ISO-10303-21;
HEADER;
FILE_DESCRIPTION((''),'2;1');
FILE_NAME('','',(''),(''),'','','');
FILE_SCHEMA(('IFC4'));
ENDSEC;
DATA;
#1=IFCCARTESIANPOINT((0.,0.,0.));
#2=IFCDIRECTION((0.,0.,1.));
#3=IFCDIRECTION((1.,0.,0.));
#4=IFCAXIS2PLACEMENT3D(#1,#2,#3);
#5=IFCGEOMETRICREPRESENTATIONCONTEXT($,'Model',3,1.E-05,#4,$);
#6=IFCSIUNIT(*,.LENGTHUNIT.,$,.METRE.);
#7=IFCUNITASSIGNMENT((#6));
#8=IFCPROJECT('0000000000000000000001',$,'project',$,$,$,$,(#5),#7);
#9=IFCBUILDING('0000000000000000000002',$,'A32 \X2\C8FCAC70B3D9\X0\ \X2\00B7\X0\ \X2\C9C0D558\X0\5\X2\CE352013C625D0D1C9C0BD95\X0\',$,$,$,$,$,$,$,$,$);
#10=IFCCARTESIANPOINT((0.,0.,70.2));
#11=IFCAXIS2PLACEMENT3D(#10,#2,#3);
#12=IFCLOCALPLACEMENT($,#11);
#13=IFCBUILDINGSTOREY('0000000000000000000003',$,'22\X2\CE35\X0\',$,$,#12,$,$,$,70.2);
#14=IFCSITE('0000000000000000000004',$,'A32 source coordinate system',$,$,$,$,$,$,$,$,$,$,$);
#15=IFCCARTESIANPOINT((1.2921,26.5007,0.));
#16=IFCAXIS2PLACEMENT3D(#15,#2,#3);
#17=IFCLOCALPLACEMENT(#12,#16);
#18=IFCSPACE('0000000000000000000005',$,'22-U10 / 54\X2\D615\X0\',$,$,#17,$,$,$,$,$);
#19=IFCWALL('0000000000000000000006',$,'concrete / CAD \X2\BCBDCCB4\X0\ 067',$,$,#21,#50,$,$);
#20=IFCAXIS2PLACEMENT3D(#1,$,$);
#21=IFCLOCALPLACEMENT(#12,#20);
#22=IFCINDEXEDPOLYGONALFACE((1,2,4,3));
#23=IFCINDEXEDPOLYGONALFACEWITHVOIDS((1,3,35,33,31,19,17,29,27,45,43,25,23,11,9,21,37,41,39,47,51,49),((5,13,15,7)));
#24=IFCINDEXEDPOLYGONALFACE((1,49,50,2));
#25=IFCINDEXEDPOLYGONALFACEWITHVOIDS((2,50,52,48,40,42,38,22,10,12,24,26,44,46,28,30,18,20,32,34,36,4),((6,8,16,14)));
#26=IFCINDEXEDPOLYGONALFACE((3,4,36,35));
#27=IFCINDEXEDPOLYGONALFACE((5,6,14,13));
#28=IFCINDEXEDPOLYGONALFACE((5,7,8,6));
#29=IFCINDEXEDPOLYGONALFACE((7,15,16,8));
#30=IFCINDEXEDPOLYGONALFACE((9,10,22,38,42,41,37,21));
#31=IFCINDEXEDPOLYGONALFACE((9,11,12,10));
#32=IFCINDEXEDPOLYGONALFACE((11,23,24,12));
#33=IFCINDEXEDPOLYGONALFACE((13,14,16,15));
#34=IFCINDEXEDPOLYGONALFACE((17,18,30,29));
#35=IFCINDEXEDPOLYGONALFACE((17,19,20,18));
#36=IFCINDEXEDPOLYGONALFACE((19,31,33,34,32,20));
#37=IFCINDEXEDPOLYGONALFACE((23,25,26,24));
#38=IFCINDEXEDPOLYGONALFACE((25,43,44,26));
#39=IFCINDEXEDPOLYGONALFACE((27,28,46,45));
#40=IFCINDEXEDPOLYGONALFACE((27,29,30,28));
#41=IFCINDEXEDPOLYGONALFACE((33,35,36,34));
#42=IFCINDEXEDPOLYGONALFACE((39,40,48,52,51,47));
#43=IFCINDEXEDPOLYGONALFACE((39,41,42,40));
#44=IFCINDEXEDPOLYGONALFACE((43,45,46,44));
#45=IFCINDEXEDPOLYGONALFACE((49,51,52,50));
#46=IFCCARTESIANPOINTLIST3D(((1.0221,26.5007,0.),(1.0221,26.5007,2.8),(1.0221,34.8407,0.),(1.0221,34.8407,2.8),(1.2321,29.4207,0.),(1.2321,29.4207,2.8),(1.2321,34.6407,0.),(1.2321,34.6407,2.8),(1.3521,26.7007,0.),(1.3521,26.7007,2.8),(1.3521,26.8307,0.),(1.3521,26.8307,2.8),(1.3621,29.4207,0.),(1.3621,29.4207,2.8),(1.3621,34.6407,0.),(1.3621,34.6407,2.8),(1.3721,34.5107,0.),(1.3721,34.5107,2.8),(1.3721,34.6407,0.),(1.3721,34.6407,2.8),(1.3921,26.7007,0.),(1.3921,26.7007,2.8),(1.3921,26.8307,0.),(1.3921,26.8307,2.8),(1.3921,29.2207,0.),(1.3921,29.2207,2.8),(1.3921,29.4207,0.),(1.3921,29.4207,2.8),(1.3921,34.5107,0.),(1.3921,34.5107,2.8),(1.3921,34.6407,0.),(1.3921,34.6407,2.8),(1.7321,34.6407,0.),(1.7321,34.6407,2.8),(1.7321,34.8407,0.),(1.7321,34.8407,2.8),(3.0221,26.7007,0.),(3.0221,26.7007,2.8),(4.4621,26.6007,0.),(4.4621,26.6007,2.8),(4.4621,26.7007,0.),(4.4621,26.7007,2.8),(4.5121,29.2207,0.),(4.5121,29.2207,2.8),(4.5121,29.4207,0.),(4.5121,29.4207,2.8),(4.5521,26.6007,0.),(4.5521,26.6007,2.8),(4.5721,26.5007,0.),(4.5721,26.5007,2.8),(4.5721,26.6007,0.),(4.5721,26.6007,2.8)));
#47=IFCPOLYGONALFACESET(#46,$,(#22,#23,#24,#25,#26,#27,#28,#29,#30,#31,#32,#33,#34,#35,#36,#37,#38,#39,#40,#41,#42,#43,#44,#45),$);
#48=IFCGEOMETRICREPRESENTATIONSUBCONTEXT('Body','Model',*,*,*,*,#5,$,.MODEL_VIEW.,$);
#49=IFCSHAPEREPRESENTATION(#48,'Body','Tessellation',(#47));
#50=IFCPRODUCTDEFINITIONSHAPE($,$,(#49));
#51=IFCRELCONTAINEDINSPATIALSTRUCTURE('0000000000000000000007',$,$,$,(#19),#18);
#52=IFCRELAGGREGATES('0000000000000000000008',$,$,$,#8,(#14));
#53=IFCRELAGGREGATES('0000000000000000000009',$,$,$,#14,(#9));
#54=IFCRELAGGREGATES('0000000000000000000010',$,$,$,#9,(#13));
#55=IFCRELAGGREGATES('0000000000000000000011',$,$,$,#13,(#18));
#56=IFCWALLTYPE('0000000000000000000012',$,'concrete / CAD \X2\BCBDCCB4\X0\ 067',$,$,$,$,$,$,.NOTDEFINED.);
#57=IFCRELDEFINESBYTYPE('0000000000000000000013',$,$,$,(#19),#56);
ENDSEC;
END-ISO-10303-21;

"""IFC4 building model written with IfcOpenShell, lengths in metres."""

from ifc_helpers import new_model, si_unit, frame, origin, origin_with_axes, place, context, subcontext, project, spatial, polyline, outline, extrude, source, transform, mapped, type_object, type_shapes, element, save


model = new_model("IFC4")

# Units and contexts
model_context = context("Model", 3, precision=1e-05, world=origin_with_axes())
body_context = subcontext(model_context, "Body", "Model", "MODEL_VIEW")
ifc_project = project(units=[si_unit("LENGTHUNIT", "METRE")], contexts=[model_context])

# Site, building, storey, space
site = spatial("IfcSite", under=ifc_project, Name="A32 source coordinate system")
building = spatial("IfcBuilding", under=site, Name="A32 주거동 · 지하5층–옥탑지붕")
storey_placement = place(None, frame((0.0, 0.0, 70.2), z_axis=(0.0, 0.0, 1.0), x_axis=(1.0, 0.0, 0.0)))
storey = spatial("IfcBuildingStorey", under=building, at=storey_placement, Name="22층", Elevation=70.2)
space_placement = place(storey_placement, frame((1.2921, 26.5007, 0.0), z_axis=(0.0, 0.0, 1.0), x_axis=(1.0, 0.0, 0.0)))
space = spatial("IfcSpace", under=storey, at=space_placement, Name="22-U10 / 54형")

# Wall
wall_type_1 = type_object("IfcWallType", Name="concrete / CAD 벽체 067", PredefinedType="NOTDEFINED")
shared_shape_1 = source(origin(), body_context, "Body", "SweptSolid", [
    extrude(outline(polyline([(0.1, 0.2), (1.73, 0.2), (3.17, 0.2), (3.17, 0.1), (3.26, 0.1), (3.28, 0.1), (3.28, 0.0), (-0.27, 0.0), (-0.27, 8.34), (0.44, 8.34), (0.44, 8.14), (0.1, 8.14), (0.08, 8.14), (0.08, 8.01), (0.1, 8.01), (0.1, 2.92), (3.22, 2.92), (3.22, 2.72), (0.1, 2.72), (0.1, 0.33), (0.06, 0.33), (0.06, 0.2), (0.1, 0.2)]), holes=[polyline([(-0.06, 8.14), (-0.06, 2.92), (0.07, 2.92), (0.07, 8.14), (-0.06, 8.14)])]), origin(), (0.0, 0.0, 1.0), 2.8),
])
type_shapes(wall_type_1, [shared_shape_1])
wall_1_placement = place(space_placement, origin_with_axes())
element("IfcWall", 1, at=wall_1_placement, inside=space, type_object=wall_type_1, Name="concrete / CAD 벽체 067", context=body_context, shape_type="MappedRepresentation", body=[
    mapped(shared_shape_1, transform((0.0, 0.0, 0.0), scale=1.0)),
])

save(model, "model.ifc")
